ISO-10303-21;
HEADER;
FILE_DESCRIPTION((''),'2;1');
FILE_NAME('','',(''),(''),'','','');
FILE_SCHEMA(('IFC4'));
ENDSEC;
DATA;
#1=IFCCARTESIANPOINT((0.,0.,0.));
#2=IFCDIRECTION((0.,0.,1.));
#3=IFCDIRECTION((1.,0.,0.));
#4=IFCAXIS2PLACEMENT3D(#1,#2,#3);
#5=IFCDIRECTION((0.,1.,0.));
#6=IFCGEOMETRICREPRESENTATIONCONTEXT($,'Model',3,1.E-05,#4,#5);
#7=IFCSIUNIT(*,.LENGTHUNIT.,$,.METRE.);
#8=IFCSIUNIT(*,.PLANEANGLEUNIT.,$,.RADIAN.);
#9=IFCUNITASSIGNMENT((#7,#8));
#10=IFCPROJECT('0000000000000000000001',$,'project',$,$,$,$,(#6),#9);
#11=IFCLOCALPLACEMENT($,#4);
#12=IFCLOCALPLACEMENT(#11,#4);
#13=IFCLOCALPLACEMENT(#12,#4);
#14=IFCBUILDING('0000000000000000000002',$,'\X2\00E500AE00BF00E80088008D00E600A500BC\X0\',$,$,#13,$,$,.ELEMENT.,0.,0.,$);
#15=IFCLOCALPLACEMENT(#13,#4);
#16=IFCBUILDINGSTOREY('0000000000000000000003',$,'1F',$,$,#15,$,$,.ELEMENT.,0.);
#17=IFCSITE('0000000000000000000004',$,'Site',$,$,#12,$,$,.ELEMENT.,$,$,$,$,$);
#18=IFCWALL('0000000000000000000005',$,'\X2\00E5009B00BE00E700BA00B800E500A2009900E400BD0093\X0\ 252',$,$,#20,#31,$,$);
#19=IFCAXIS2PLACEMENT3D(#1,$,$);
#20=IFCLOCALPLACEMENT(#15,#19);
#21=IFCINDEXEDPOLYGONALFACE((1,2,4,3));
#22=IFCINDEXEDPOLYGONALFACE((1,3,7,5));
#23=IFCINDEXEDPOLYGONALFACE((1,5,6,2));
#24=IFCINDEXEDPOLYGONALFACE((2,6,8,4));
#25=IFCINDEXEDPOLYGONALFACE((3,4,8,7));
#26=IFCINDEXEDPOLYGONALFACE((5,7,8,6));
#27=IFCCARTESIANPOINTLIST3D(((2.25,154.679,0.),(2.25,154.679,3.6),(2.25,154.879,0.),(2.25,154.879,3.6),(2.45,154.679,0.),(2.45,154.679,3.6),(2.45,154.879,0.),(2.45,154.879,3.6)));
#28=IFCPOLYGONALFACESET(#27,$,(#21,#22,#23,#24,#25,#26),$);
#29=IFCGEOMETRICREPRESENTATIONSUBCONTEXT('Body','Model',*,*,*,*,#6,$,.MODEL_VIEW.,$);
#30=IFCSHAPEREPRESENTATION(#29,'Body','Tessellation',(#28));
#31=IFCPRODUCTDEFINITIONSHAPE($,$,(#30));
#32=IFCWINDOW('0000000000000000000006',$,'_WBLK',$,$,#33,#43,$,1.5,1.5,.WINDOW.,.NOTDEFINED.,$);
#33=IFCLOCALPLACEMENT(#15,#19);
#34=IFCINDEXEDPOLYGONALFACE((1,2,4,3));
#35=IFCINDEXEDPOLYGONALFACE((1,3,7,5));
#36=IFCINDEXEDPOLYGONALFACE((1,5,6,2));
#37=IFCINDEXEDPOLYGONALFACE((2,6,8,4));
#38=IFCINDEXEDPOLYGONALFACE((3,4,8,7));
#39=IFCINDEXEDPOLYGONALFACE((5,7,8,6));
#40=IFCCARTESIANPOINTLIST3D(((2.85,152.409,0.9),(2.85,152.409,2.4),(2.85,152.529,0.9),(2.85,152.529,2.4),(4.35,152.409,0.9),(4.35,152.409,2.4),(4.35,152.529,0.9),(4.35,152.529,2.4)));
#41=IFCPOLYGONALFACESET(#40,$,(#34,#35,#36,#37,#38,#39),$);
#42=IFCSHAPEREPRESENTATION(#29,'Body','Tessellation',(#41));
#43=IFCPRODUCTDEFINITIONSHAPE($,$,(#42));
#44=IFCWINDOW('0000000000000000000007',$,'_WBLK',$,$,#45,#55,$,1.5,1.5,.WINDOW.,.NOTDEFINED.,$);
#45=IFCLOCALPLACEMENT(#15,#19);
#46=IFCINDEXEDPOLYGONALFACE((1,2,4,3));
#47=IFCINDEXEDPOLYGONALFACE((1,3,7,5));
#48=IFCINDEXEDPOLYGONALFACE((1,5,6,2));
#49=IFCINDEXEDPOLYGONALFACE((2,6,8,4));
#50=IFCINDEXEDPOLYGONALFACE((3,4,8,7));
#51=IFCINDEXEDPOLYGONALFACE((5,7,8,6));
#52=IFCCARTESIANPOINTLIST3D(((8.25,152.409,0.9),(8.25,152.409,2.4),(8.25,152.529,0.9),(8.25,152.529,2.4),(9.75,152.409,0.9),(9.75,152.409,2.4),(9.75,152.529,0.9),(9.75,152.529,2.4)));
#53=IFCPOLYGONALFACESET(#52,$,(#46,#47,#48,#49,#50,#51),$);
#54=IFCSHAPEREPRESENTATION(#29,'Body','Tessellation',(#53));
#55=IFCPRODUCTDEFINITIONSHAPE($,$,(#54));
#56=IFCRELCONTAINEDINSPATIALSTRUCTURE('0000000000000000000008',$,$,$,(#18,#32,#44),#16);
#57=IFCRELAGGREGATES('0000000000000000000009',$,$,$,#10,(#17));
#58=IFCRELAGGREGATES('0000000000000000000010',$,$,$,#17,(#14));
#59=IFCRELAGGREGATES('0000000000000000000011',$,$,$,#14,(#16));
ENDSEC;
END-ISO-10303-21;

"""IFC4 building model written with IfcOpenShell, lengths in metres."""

from ifc_helpers import new_model, si_unit, direction, frame, frame_2d, origin_with_axes, place, context, subcontext, project, spatial, rectangle, extrude, element, save


model = new_model("IFC4")

# Units and contexts
model_context = context("Model", 3, precision=1e-05, world=origin_with_axes(), true_north=direction((0.0, 1.0, 0.0)))
body_context = subcontext(model_context, "Body", "Model", "MODEL_VIEW")
ifc_project = project(units=[si_unit("LENGTHUNIT", "METRE"), si_unit("PLANEANGLEUNIT", "RADIAN")], contexts=[model_context])

# Site, building, storey
placement = place(None, origin_with_axes())
site_placement = place(placement, origin_with_axes())
site = spatial("IfcSite", under=ifc_project, at=site_placement, Name="Site", CompositionType="ELEMENT")
building_placement = place(site_placement, origin_with_axes())
building = spatial("IfcBuilding", under=site, at=building_placement, Name="å®¿è\u0088\u008dæ¥¼", CompositionType="ELEMENT", ElevationOfRefHeight=0.0, ElevationOfTerrain=0.0)
storey_placement = place(building_placement, origin_with_axes())
storey = spatial("IfcBuildingStorey", under=building, at=storey_placement, Name="1F", CompositionType="ELEMENT", Elevation=0.0)

# Wall
for number, where, z_axis, x_axis, name in (
    (1, (2.35, 154.779, 0.0), (0.0, 0.0, 1.0), (0.0, 1.0, 0.0), "å\u009b¾çº¸å¢\u0099ä½\u0093 252"),
):
    element("IfcWall", number, at=place(storey_placement, frame(where, z_axis=z_axis, x_axis=x_axis)), inside=storey, Name=name, context=body_context, shape_type="SweptSolid", body=[
        extrude(rectangle(XDim=0.2, YDim=0.2, at=frame_2d((0.0, 0.0), x_axis=(1.0, 0.0, 0.0))), frame((0.0, 0.0, 0.0), z_axis=(0.0, 0.0, 1.0)), (0.0, 0.0, 1.0), 3.6),
    ])

# Windows
for number, where, z_axis, x_axis, name in (
    (2, (3.6, 152.469, 0.9), (0.0, 0.0, 1.0), (1.0, 0.0, 0.0), "_WBLK"),
    (3, (9.0, 152.469, 0.9), (0.0, 0.0, 1.0), (1.0, 0.0, 0.0), "_WBLK"),
):
    element("IfcWindow", number, at=place(storey_placement, frame(where, z_axis=z_axis, x_axis=x_axis)), inside=storey, Name=name, OverallHeight=1.5, OverallWidth=1.5, PartitioningType="NOTDEFINED", PredefinedType="WINDOW", context=body_context, shape_type="SweptSolid", body=[
        extrude(rectangle(XDim=1.5, YDim=0.12, at=frame_2d((0.0, 0.0), x_axis=(1.0, 0.0, 0.0))), frame((0.0, 0.0, 0.0), z_axis=(0.0, 0.0, 1.0)), (0.0, 0.0, 1.0), 1.5),
    ])

save(model, "model.ifc")
